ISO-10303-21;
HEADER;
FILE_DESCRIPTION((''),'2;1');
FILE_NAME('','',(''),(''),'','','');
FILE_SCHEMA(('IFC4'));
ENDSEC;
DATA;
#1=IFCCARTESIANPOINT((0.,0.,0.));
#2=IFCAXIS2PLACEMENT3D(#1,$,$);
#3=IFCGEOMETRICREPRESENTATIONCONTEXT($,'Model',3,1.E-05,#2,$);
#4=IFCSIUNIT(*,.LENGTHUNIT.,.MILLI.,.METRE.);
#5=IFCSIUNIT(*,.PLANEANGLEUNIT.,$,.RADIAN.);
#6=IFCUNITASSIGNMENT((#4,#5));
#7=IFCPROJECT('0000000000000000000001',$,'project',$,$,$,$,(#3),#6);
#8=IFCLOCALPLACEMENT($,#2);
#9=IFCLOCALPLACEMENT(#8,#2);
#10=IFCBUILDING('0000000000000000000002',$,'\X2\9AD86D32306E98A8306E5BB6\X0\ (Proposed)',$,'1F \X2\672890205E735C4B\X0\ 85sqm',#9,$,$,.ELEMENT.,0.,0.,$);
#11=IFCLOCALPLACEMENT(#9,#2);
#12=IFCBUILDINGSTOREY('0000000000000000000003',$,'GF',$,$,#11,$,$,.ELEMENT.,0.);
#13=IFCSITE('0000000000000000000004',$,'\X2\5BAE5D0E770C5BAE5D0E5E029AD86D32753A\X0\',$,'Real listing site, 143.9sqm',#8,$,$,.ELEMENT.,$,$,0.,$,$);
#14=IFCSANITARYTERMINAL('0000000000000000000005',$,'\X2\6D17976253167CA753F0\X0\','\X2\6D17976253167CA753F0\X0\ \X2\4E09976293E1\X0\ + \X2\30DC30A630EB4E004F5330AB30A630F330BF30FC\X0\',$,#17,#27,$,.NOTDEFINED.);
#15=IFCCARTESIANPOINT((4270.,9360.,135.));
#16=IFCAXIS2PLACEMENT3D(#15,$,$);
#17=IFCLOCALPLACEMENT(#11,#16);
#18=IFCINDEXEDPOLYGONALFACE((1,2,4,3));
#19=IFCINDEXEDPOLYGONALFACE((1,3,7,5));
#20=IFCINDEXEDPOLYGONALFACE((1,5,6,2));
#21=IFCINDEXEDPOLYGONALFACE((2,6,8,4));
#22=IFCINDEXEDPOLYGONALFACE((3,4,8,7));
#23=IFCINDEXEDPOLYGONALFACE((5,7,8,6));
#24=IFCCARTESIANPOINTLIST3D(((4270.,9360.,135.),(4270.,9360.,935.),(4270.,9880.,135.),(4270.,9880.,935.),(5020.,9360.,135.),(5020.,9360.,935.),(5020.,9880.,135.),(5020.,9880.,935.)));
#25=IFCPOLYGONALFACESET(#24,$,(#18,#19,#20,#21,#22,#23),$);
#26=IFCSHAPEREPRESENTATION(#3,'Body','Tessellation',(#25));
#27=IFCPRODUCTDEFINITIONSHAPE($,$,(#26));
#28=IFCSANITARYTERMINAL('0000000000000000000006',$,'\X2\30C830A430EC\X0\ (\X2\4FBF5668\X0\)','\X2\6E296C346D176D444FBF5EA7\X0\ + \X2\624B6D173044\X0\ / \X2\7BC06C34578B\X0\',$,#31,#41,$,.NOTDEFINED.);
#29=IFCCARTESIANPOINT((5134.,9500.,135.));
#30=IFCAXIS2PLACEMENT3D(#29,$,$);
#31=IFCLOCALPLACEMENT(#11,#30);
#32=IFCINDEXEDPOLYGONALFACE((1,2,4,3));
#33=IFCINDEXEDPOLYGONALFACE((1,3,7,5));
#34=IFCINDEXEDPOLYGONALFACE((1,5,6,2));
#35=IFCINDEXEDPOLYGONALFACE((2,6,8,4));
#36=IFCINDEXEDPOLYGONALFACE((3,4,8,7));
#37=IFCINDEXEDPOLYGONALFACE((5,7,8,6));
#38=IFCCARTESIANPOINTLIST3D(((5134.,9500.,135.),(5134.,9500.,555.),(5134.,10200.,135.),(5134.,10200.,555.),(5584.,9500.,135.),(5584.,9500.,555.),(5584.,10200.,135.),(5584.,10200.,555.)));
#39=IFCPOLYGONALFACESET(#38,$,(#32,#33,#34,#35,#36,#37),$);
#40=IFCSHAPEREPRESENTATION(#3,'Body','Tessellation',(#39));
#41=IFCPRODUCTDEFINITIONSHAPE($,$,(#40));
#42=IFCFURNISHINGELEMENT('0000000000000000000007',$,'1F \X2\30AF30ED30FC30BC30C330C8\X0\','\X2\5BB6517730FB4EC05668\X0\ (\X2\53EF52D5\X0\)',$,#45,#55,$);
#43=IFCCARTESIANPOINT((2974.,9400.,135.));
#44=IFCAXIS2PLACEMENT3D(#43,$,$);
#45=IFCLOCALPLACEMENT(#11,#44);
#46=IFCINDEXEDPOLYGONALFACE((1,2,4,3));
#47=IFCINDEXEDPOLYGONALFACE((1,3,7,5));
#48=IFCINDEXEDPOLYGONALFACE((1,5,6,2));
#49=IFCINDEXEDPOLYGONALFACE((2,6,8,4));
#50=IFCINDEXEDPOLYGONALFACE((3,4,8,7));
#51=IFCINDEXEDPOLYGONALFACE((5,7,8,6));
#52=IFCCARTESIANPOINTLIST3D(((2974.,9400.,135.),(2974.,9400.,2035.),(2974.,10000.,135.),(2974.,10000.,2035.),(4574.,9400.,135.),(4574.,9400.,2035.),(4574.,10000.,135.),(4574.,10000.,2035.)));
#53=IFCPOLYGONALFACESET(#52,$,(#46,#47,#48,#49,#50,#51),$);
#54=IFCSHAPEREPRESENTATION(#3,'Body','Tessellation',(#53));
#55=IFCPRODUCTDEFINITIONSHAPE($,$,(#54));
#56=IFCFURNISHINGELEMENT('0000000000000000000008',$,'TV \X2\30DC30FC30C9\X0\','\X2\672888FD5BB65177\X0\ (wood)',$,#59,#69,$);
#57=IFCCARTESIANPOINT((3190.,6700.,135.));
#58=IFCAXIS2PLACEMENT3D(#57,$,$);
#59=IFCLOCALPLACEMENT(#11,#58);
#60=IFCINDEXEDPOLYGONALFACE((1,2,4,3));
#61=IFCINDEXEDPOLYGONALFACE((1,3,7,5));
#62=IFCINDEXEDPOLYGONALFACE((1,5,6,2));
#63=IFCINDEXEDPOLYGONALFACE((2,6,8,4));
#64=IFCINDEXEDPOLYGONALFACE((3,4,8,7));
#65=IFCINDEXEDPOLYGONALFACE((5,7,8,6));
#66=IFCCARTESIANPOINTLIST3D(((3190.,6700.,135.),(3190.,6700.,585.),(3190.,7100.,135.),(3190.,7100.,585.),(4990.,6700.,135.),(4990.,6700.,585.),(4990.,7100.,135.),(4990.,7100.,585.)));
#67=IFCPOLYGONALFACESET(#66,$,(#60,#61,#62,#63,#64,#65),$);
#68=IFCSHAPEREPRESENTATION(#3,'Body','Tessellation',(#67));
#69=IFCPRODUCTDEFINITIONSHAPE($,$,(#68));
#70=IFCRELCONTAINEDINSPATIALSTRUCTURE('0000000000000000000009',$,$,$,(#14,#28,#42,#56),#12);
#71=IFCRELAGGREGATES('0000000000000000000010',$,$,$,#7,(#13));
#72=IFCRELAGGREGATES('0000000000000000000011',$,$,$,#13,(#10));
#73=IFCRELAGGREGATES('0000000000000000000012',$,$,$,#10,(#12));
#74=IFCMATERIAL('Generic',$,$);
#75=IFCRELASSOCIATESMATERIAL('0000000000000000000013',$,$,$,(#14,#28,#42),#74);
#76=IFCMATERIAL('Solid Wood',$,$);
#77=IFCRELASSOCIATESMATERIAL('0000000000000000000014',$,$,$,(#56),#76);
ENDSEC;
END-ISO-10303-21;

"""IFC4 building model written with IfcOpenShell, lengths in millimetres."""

from ifc_helpers import new_model, si_unit, frame, frame_2d, origin, place, context, project, spatial, rectangle, extrude, material, element, save


model = new_model("IFC4")

# Units and contexts
model_context = context("Model", 3, precision=1e-05, world=origin())
ifc_project = project(units=[si_unit("LENGTHUNIT", "METRE", prefix="MILLI"), si_unit("PLANEANGLEUNIT", "RADIAN")], contexts=[model_context])

# Site, building, storey
site_placement = place(None, origin())
site = spatial("IfcSite", under=ifc_project, at=site_placement, Name="宮崎県宮崎市高洲町", ObjectType="Real listing site, 143.9sqm", CompositionType="ELEMENT", RefElevation=0.0)
building_placement = place(site_placement, origin())
building = spatial("IfcBuilding", under=site, at=building_placement, Name="高洲の風の家 (Proposed)", ObjectType="1F 木造平屋 85sqm", CompositionType="ELEMENT", ElevationOfRefHeight=0.0, ElevationOfTerrain=0.0)
storey_placement = place(building_placement, origin())
storey = spatial("IfcBuildingStorey", under=building, at=storey_placement, Name="GF", CompositionType="ELEMENT", Elevation=0.0)

# Shared definitions
ifc_material_1 = material(Name="Solid Wood")

# Shared definitions
ifc_material_2 = material(Name="Generic")

# Sanitary terminals
sanitary_terminal_1_placement = place(storey_placement, frame((4270.0, 9360.0, 135.0)))
element("IfcSanitaryTerminal", 1, at=sanitary_terminal_1_placement, inside=storey, material=ifc_material_2, Name="洗面化粧台", Description="洗面化粧台 三面鏡 + ボウル一体カウンター", PredefinedType="NOTDEFINED", context=model_context, shape_type="SweptSolid", body=[
    extrude(rectangle(XDim=750.0, YDim=520.0, at=frame_2d((375.0, 260.0))), frame((4270.0, 9360.0, 135.0)), (0.0, 0.0, 1.0), 800.0),
])
sanitary_terminal_2_placement = place(storey_placement, frame((5134.0, 9500.0, 135.0)))
element("IfcSanitaryTerminal", 2, at=sanitary_terminal_2_placement, inside=storey, material=ifc_material_2, Name="トイレ (便器)", Description="温水洗浄便座 + 手洗い / 節水型", PredefinedType="NOTDEFINED", context=model_context, shape_type="SweptSolid", body=[
    extrude(rectangle(XDim=450.0, YDim=700.0, at=frame_2d((225.0, 350.0))), frame((5134.0, 9500.0, 135.0)), (0.0, 0.0, 1.0), 420.0),
])

# Furnishing elements
furnishing_1_placement = place(storey_placement, frame((2974.0, 9400.0, 135.0)))
element("IfcFurnishingElement", 3, at=furnishing_1_placement, inside=storey, material=ifc_material_2, Name="1F クローゼット", Description="家具・什器 (可動)", context=model_context, shape_type="SweptSolid", body=[
    extrude(rectangle(XDim=1600.0, YDim=600.0, at=frame_2d((800.0, 300.0))), frame((2974.0, 9400.0, 135.0)), (0.0, 0.0, 1.0), 1900.0),
])
furnishing_2_placement = place(storey_placement, frame((3190.0, 6700.0, 135.0)))
element("IfcFurnishingElement", 4, at=furnishing_2_placement, inside=storey, material=ifc_material_1, Name="TV ボード", Description="木製家具 (wood)", context=model_context, shape_type="SweptSolid", body=[
    extrude(rectangle(XDim=1800.0, YDim=400.0, at=frame_2d((900.0, 200.0))), frame((3190.0, 6700.0, 135.0)), (0.0, 0.0, 1.0), 450.0),
])

save(model, "model.ifc")
